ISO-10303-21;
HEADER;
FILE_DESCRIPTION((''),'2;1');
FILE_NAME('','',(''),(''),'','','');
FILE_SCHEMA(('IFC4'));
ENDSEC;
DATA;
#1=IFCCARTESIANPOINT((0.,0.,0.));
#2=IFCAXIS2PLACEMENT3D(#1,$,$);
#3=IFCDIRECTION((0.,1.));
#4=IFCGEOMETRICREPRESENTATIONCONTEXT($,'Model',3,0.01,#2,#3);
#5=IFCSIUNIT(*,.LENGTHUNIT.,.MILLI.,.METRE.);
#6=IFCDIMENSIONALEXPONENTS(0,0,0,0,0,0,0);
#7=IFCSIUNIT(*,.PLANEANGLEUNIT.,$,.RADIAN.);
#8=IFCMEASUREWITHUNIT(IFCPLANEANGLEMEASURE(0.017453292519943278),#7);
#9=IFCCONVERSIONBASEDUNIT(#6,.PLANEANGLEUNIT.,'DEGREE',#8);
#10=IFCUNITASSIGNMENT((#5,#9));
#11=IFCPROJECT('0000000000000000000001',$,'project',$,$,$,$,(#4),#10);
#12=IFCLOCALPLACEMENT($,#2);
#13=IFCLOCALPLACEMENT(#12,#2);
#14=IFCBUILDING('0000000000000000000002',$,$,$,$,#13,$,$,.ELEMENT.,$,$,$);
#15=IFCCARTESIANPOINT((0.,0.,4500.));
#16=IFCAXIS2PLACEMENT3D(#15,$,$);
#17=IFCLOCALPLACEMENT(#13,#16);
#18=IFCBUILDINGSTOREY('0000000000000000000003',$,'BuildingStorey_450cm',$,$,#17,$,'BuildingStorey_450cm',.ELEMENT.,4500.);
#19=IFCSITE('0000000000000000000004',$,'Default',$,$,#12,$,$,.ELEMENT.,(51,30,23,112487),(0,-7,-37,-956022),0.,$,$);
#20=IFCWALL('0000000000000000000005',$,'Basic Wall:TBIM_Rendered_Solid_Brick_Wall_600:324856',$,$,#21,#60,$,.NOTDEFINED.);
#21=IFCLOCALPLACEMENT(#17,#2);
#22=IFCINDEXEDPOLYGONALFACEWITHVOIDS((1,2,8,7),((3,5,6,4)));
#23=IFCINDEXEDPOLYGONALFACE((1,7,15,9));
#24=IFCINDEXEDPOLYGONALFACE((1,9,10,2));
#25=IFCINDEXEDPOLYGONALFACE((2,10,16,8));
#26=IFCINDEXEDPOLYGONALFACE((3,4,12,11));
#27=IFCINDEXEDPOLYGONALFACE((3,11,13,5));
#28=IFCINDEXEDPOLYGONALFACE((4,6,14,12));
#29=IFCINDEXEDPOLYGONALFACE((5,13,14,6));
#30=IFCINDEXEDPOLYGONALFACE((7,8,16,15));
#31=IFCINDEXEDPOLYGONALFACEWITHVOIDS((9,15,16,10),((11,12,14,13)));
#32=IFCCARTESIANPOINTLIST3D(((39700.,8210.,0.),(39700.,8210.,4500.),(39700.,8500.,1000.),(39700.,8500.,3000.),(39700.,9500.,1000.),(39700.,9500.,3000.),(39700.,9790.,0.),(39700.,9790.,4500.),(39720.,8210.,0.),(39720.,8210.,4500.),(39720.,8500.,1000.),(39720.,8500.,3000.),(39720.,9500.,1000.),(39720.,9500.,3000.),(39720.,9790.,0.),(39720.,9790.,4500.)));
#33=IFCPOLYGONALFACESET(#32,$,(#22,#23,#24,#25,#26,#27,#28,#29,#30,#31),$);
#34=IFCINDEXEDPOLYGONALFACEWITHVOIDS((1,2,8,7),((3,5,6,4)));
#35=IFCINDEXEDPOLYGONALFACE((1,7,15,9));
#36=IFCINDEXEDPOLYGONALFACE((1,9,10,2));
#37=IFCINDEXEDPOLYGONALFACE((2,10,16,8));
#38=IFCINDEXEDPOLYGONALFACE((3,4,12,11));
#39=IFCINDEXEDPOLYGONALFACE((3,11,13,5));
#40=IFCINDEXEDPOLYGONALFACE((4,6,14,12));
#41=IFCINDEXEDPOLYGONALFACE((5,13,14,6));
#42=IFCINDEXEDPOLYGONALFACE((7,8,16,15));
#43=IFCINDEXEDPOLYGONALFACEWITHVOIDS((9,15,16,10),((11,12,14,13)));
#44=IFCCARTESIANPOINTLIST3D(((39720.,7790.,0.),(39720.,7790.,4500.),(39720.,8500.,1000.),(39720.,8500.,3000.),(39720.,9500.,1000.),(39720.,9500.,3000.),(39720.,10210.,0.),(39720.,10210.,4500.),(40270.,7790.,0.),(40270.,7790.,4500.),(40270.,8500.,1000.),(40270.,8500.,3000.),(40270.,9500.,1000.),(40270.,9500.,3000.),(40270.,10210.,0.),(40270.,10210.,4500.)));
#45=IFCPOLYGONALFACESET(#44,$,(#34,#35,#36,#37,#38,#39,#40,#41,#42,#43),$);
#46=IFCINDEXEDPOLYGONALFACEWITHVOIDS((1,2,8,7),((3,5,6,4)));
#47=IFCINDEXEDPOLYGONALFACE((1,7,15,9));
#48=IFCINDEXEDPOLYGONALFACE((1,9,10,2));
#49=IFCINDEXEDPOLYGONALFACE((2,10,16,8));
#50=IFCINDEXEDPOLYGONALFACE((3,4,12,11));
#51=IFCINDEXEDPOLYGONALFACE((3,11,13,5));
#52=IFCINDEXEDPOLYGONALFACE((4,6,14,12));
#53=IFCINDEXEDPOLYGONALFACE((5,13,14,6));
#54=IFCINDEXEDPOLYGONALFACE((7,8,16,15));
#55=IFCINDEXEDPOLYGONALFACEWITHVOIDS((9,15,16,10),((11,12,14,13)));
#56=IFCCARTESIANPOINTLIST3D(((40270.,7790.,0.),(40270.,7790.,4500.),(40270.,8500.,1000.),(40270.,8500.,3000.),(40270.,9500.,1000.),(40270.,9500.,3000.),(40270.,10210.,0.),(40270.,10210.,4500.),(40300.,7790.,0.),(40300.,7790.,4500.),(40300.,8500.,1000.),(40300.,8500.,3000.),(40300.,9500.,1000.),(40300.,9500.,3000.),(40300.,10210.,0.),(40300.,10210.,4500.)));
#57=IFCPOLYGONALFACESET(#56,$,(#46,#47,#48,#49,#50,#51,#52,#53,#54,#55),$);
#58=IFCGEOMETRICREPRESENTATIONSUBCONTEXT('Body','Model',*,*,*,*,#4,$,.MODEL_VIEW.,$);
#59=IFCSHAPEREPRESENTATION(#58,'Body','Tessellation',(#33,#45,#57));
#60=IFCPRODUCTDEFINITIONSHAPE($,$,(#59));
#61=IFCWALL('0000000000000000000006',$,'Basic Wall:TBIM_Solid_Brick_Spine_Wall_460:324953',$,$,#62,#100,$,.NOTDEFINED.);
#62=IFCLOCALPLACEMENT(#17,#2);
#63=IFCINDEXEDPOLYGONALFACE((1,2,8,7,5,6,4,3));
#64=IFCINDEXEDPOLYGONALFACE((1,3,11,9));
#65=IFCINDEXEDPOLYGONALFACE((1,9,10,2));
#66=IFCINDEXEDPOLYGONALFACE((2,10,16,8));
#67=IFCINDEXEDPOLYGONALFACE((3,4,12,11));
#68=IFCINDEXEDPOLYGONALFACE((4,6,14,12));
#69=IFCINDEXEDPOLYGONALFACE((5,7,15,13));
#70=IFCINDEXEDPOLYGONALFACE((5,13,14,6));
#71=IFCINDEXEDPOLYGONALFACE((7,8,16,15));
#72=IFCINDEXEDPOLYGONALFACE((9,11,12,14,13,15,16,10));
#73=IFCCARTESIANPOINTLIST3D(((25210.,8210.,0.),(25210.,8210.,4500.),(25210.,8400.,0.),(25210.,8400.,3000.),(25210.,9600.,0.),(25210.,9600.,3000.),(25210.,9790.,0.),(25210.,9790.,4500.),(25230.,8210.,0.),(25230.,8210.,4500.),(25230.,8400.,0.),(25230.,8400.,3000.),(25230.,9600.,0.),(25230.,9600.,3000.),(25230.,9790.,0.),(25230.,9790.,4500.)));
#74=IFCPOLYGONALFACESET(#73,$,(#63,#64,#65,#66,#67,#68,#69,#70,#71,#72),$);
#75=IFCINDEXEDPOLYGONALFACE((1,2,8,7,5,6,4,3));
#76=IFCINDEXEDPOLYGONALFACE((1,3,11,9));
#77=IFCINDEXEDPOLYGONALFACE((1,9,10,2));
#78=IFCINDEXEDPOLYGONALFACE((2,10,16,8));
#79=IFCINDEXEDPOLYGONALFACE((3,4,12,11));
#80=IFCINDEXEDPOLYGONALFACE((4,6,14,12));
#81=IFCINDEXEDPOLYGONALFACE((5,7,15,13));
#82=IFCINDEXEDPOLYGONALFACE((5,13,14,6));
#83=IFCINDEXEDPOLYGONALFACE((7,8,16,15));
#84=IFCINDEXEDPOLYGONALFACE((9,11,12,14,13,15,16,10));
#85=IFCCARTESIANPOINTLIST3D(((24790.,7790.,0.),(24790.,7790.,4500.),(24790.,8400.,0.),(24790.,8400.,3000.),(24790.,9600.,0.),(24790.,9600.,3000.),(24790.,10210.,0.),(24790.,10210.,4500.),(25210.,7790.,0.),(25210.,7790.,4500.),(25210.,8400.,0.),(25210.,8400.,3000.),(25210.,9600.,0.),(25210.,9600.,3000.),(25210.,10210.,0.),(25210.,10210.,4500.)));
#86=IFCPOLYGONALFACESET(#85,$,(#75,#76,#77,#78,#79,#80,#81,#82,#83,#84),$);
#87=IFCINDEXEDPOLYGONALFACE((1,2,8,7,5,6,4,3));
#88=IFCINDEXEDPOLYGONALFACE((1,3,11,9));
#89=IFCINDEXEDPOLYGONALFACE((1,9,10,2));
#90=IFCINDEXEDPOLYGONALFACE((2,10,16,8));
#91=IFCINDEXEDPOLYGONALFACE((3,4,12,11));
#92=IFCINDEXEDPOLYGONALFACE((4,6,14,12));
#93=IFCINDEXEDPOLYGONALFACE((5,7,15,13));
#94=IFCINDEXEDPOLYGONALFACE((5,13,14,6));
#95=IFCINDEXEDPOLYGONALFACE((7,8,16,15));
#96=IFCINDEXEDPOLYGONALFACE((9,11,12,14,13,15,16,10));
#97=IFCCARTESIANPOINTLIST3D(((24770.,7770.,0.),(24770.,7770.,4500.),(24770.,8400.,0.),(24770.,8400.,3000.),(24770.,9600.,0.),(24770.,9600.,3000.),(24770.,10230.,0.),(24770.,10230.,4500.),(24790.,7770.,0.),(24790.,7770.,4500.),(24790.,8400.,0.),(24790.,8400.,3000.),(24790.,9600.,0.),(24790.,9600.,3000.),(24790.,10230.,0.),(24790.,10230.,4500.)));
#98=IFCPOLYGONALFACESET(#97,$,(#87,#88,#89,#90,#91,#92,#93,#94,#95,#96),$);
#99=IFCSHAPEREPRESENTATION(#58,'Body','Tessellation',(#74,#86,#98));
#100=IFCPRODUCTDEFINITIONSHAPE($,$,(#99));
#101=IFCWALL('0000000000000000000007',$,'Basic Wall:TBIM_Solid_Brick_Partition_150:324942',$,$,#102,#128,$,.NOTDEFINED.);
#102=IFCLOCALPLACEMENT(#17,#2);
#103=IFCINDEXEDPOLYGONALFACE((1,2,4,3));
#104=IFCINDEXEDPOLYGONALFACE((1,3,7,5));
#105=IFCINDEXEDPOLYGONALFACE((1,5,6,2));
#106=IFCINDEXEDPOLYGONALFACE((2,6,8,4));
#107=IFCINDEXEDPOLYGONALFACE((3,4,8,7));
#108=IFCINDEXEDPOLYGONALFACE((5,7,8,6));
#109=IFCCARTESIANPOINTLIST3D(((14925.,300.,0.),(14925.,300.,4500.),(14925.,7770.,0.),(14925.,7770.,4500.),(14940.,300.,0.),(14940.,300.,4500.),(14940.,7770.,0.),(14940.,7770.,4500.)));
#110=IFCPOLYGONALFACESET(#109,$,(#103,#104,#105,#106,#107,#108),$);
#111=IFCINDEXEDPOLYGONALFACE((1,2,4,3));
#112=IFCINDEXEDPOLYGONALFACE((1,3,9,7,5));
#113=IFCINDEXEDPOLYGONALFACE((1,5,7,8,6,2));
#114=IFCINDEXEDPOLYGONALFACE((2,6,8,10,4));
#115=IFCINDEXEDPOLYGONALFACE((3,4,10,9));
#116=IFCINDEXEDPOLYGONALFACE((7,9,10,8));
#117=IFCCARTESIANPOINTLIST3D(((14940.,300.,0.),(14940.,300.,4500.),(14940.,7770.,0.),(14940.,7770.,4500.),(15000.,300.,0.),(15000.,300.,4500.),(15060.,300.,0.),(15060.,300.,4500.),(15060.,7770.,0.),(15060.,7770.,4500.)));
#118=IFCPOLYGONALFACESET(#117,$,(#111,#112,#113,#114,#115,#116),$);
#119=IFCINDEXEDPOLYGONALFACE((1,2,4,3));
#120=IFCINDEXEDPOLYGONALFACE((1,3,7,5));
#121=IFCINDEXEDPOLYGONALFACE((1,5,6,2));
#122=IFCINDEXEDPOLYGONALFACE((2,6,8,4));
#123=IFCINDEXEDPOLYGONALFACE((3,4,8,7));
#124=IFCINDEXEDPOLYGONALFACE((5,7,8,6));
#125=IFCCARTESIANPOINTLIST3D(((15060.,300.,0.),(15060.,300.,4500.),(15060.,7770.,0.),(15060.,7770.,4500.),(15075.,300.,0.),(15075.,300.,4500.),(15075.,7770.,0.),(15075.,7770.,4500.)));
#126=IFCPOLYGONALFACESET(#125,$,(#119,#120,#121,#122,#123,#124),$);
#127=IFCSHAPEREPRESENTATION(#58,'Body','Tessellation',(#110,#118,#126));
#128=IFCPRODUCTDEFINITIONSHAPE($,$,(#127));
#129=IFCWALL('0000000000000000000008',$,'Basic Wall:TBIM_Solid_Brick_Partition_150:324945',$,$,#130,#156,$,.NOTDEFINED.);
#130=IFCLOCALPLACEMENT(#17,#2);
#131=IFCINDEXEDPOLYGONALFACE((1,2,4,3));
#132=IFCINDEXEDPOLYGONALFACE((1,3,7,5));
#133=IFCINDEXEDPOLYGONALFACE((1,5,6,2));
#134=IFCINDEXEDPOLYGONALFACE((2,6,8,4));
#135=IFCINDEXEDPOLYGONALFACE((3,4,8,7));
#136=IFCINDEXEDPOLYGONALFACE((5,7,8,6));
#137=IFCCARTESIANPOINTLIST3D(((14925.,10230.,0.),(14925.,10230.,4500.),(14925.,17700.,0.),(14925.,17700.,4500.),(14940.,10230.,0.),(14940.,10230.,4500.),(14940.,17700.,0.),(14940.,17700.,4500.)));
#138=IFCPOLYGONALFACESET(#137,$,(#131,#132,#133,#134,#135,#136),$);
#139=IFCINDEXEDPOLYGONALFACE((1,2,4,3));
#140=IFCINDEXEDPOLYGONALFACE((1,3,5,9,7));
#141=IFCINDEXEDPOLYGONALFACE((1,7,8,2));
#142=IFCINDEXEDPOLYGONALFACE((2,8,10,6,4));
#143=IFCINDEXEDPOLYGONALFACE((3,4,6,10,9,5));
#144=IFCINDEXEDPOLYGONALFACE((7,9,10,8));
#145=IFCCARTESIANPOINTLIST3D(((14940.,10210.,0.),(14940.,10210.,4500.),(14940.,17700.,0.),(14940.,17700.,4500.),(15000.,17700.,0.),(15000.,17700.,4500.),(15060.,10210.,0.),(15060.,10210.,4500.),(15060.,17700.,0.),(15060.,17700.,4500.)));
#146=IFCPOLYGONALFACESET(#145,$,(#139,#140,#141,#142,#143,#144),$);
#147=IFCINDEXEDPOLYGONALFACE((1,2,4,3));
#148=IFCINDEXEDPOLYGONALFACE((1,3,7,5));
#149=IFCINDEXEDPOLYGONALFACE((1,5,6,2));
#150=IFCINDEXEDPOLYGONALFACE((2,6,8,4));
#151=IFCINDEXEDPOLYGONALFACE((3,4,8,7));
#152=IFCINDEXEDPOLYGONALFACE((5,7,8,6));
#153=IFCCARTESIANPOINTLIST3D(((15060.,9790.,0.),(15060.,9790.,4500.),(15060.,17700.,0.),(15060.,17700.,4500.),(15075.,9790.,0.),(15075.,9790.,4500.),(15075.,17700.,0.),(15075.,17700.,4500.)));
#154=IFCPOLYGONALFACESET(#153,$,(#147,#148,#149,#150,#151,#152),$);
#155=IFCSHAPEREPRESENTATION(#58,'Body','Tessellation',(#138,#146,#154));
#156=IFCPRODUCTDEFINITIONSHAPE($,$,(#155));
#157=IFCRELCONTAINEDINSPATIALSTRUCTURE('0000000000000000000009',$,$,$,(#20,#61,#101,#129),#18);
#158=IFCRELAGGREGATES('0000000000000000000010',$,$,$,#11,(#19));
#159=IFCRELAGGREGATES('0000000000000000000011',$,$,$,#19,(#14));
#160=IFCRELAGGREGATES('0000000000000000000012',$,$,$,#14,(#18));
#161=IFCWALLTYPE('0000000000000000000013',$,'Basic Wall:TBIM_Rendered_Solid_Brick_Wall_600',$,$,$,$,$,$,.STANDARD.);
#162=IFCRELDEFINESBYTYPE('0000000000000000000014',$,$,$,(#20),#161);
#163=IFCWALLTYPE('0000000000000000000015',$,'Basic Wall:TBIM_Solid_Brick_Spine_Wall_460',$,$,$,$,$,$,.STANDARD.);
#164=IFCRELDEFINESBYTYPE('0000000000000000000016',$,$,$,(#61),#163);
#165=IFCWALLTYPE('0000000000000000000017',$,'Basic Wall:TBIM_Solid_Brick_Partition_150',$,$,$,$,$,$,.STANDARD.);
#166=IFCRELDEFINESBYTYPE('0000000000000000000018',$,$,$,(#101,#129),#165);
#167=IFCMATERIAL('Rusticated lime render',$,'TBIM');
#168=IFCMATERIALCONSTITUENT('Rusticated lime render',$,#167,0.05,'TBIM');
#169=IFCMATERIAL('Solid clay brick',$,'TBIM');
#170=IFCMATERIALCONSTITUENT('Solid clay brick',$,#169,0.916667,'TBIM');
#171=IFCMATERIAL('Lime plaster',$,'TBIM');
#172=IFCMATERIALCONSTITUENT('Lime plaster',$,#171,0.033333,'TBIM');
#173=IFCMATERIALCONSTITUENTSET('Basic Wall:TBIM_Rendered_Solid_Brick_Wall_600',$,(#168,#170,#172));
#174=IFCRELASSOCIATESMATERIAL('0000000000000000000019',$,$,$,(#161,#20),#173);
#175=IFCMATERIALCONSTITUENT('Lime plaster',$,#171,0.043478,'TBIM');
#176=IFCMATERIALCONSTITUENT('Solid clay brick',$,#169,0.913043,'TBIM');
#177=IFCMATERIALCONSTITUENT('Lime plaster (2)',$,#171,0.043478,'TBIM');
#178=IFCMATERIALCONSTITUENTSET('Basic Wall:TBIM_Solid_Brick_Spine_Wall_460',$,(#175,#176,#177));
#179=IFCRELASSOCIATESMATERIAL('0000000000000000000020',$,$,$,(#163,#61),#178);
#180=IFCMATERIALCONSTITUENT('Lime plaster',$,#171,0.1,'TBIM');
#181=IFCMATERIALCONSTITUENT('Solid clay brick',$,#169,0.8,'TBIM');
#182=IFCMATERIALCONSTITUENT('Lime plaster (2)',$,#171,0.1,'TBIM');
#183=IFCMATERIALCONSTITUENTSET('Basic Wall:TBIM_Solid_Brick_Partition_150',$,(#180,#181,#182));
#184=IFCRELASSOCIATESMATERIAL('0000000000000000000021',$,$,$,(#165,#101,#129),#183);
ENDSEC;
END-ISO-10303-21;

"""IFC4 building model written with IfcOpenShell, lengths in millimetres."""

from ifc_helpers import new_model, entity, si_unit, converted_unit, direction, frame, origin, place, context, subcontext, project, spatial, indexed_curve, outline, extrude, material, constituent, constituent_set, type_object, element, save


model = new_model("IFC4")

# Units and contexts
model_context = context("Model", 3, precision=0.01, world=origin(), true_north=direction((0.0, 1.0)))
body_context = subcontext(model_context, "Body", "Model", "MODEL_VIEW")
ifc_project = project(units=[si_unit("LENGTHUNIT", "METRE", prefix="MILLI"), converted_unit("PLANEANGLEUNIT", "DEGREE", entity("IfcPlaneAngleMeasure", 0.017453292519943278), si_unit("PLANEANGLEUNIT", "RADIAN"), dimensions=[0, 0, 0, 0, 0, 0, 0])], contexts=[model_context])

# Site, building, storey
site_placement = place(None, origin())
site = spatial("IfcSite", under=ifc_project, at=site_placement, Name="Default", CompositionType="ELEMENT", RefLatitude=(51, 30, 23, 112487), RefLongitude=(0, -7, -37, -956022), RefElevation=0.0)
building_placement = place(site_placement, origin())
building = spatial("IfcBuilding", under=site, at=building_placement, CompositionType="ELEMENT")
storey_placement = place(building_placement, frame((0.0, 0.0, 4500.0)))
storey = spatial("IfcBuildingStorey", under=building, at=storey_placement, Name="BuildingStorey_450cm", LongName="BuildingStorey_450cm", CompositionType="ELEMENT", Elevation=4500.0)

# Walls, openings
ifc_material_1 = material(Name="Rusticated lime render", Category="TBIM")
ifc_constituent_1 = constituent(ifc_material_1, Name="Rusticated lime render", Category="TBIM", fraction=0.05)
ifc_material_2 = material(Name="Solid clay brick", Category="TBIM")
ifc_constituent_2 = constituent(ifc_material_2, Name="Solid clay brick", Category="TBIM", fraction=0.916667)
ifc_material_3 = material(Name="Lime plaster", Category="TBIM")
ifc_constituent_3 = constituent(ifc_material_3, Name="Lime plaster", Category="TBIM", fraction=0.033333)
ifc_constituent_set_1 = constituent_set(constituents=[ifc_constituent_1, ifc_constituent_2, ifc_constituent_3], Name="Basic Wall:TBIM_Rendered_Solid_Brick_Wall_600")
wall_type_1 = type_object("IfcWallType", Name="Basic Wall:TBIM_Rendered_Solid_Brick_Wall_600", PredefinedType="STANDARD", material=ifc_constituent_set_1)
wall_1_placement = place(storey_placement, frame((40000.0, 10230.0, 0.0), z_axis=(0.0, 0.0, 1.0), x_axis=(0.0, -1.0, 0.0)))
wall_1 = element("IfcWall", 1, at=wall_1_placement, inside=storey, type_object=wall_type_1, material=ifc_constituent_set_1, Name="Basic Wall:TBIM_Rendered_Solid_Brick_Wall_600:324856", PredefinedType="NOTDEFINED", context=body_context, shape_type="SweptSolid", body=[
    extrude(outline(indexed_curve([(-2250.0, -790.0), (2250.0, -790.0), (2250.0, -770.0), (2250.0, 770.0), (2250.0, 790.0), (-2250.0, 790.0), (-2250.0, 770.0), (-2250.0, -770.0), (-2250.0, -790.0)], self_intersect=False), holes=[indexed_curve([(750.0, -500.0), (-1250.0, -500.0), (-1250.0, 500.0), (750.0, 500.0), (750.0, -500.0)], self_intersect=False)]), frame((1230.0, -300.0, 2250.0), z_axis=(0.0, 1.0, 0.0), x_axis=(0.0, 0.0, 1.0)), (0.0, 0.0, 1.0), 20.0),
    extrude(outline(indexed_curve([(-2250.0, -1210.0), (2250.0, -1210.0), (2250.0, 1210.0), (-2250.0, 1210.0), (-2250.0, -1210.0)], self_intersect=False), holes=[indexed_curve([(-1250.0, -500.0), (-1250.0, 500.0), (750.0, 500.0), (750.0, -500.0), (-1250.0, -500.0)], self_intersect=False)]), frame((1230.0, -280.0, 2250.0), z_axis=(0.0, 1.0, 0.0), x_axis=(0.0, 0.0, 1.0)), (0.0, 0.0, 1.0), 550.0),
    extrude(outline(indexed_curve([(-2250.0, -1210.0), (2250.0, -1210.0), (2250.0, 1210.0), (-2250.0, 1210.0), (-2250.0, -1210.0)], self_intersect=False), holes=[indexed_curve([(-1250.0, -500.0), (-1250.0, 500.0), (750.0, 500.0), (750.0, -500.0), (-1250.0, -500.0)], self_intersect=False)]), frame((1230.0, 270.0, 2250.0), z_axis=(0.0, 1.0, 0.0), x_axis=(0.0, 0.0, 1.0)), (0.0, 0.0, 1.0), 30.0),
])
opening_1_placement = place(wall_1_placement, frame((730.0, -300.0, 1000.0)))
element("IfcOpeningElement", 2, at=opening_1_placement, cuts=wall_1, PredefinedType="OPENING", context=body_context, shape_type="SweptSolid", body=[
    extrude(outline(indexed_curve([(2000.0, 0.0), (2000.0, 1000.0), (0.0, 1000.0), (0.0, 0.0), (2000.0, 0.0)], self_intersect=False)), frame((0.0, 0.0, 0.0), z_axis=(0.0, 1.0, 0.0), x_axis=(0.0, 0.0, 1.0)), (0.0, 0.0, 1.0), 600.0),
])
ifc_constituent_4 = constituent(ifc_material_3, Name="Lime plaster", Category="TBIM", fraction=0.043478)
ifc_constituent_5 = constituent(ifc_material_2, Name="Solid clay brick", Category="TBIM", fraction=0.913043)
ifc_constituent_6 = constituent(ifc_material_3, Name="Lime plaster (2)", Category="TBIM", fraction=0.043478)
ifc_constituent_set_2 = constituent_set(constituents=[ifc_constituent_4, ifc_constituent_5, ifc_constituent_6], Name="Basic Wall:TBIM_Solid_Brick_Spine_Wall_460")
wall_type_2 = type_object("IfcWallType", Name="Basic Wall:TBIM_Solid_Brick_Spine_Wall_460", PredefinedType="STANDARD", material=ifc_constituent_set_2)
wall_2_placement = place(storey_placement, frame((25000.0, 10230.0, 0.0), z_axis=(0.0, 0.0, 1.0), x_axis=(0.0, -1.0, 0.0)))
wall_2 = element("IfcWall", 3, at=wall_2_placement, inside=storey, type_object=wall_type_2, material=ifc_constituent_set_2, Name="Basic Wall:TBIM_Solid_Brick_Spine_Wall_460:324953", PredefinedType="NOTDEFINED", context=body_context, shape_type="SweptSolid", body=[
    extrude(outline(indexed_curve([(-1875.0, -790.0), (2625.0, -790.0), (2625.0, 790.0), (-1875.0, 790.0), (-1875.0, 600.0), (1125.0, 600.0), (1125.0, -600.0), (-1875.0, -600.0), (-1875.0, -790.0)], self_intersect=False)), frame((1230.0, 210.0, 1875.0), z_axis=(0.0, 1.0, 0.0), x_axis=(0.0, 0.0, 1.0)), (0.0, 0.0, 1.0), 20.0),
    extrude(outline(indexed_curve([(-1875.0, -1210.0), (2625.0, -1210.0), (2625.0, 1210.0), (-1875.0, 1210.0), (-1875.0, 600.0), (1125.0, 600.0), (1125.0, -600.0), (-1875.0, -600.0), (-1875.0, -1210.0)], self_intersect=False)), frame((1230.0, -210.0, 1875.0), z_axis=(0.0, 1.0, 0.0), x_axis=(0.0, 0.0, 1.0)), (0.0, 0.0, 1.0), 420.0),
    extrude(outline(indexed_curve([(-2625.0, -1230.0), (1875.0, -1230.0), (1875.0, -600.0), (-1125.0, -600.0), (-1125.0, 600.0), (1875.0, 600.0), (1875.0, 1230.0), (-2625.0, 1230.0), (-2625.0, -1230.0)], self_intersect=False)), frame((1230.0, -230.0, 1875.0), z_axis=(0.0, 1.0, 0.0), x_axis=(0.0, 0.0, -1.0)), (0.0, 0.0, 1.0), 20.0),
])
opening_2_placement = place(wall_2_placement, frame((630.0, -230.0, 0.0)))
element("IfcOpeningElement", 4, at=opening_2_placement, cuts=wall_2, PredefinedType="OPENING", context=body_context, shape_type="SweptSolid", body=[
    extrude(outline(indexed_curve([(0.0, 1200.0), (0.0, 0.0), (3000.0, 0.0), (3000.0, 1200.0), (0.0, 1200.0)], self_intersect=False)), frame((0.0, 0.0, 0.0), z_axis=(0.0, 1.0, 0.0), x_axis=(0.0, 0.0, 1.0)), (0.0, 0.0, 1.0), 460.0),
])

# Walls
ifc_constituent_7 = constituent(ifc_material_3, Name="Lime plaster", Category="TBIM", fraction=0.1)
ifc_constituent_8 = constituent(ifc_material_2, Name="Solid clay brick", Category="TBIM", fraction=0.8)
ifc_constituent_9 = constituent(ifc_material_3, Name="Lime plaster (2)", Category="TBIM", fraction=0.1)
ifc_constituent_set_3 = constituent_set(constituents=[ifc_constituent_7, ifc_constituent_8, ifc_constituent_9], Name="Basic Wall:TBIM_Solid_Brick_Partition_150")
wall_type_3 = type_object("IfcWallType", Name="Basic Wall:TBIM_Solid_Brick_Partition_150", PredefinedType="STANDARD", material=ifc_constituent_set_3)
wall_3_placement = place(storey_placement, frame((15000.0, 300.0, 0.0), z_axis=(0.0, 0.0, 1.0), x_axis=(0.0, 1.0, 0.0)))
element("IfcWall", 5, at=wall_3_placement, inside=storey, type_object=wall_type_3, material=ifc_constituent_set_3, Name="Basic Wall:TBIM_Solid_Brick_Partition_150:324942", PredefinedType="NOTDEFINED", context=body_context, shape_type="SweptSolid", body=[
    extrude(outline(indexed_curve([(-7.5, -3735.0), (7.5, -3735.0), (7.5, 3735.0), (-7.5, 3735.0), (-7.5, -3735.0)], self_intersect=False)), frame((3735.0, 67.5, 0.0), z_axis=(0.0, 0.0, 1.0), x_axis=(0.0, -1.0, 0.0)), (0.0, 0.0, 1.0), 4500.0),
    extrude(outline(indexed_curve([(-2988.0, -60.0), (4482.0, -60.0), (4482.0, 60.0), (-2988.0, 60.0), (-2988.0, 0.0), (-2988.0, -60.0)], self_intersect=False)), frame((2988.0, 0.0, 0.0)), (0.0, 0.0, 1.0), 4500.0),
    extrude(outline(indexed_curve([(-7.5, -3735.0), (7.5, -3735.0), (7.5, 3735.0), (-7.5, 3735.0), (-7.5, -3735.0)], self_intersect=False)), frame((3735.0, -67.5, 0.0), z_axis=(0.0, 0.0, 1.0), x_axis=(0.0, 1.0, 0.0)), (0.0, 0.0, 1.0), 4500.0),
])
wall_4_placement = place(storey_placement, frame((15000.0, 10230.0, 0.0), z_axis=(0.0, 0.0, 1.0), x_axis=(0.0, 1.0, 0.0)))
element("IfcWall", 6, at=wall_4_placement, inside=storey, type_object=wall_type_3, material=ifc_constituent_set_3, Name="Basic Wall:TBIM_Solid_Brick_Partition_150:324945", PredefinedType="NOTDEFINED", context=body_context, shape_type="SweptSolid", body=[
    extrude(outline(indexed_curve([(-7.5, -3735.0), (7.5, -3735.0), (7.5, 3735.0), (-7.5, 3735.0), (-7.5, -3735.0)], self_intersect=False)), frame((3735.0, 67.5, 0.0), z_axis=(0.0, 0.0, 1.0), x_axis=(0.0, -1.0, 0.0)), (0.0, 0.0, 1.0), 4500.0),
    extrude(outline(indexed_curve([(-4494.0, -60.0), (2996.0, -60.0), (2996.0, 0.0), (2996.0, 60.0), (-4494.0, 60.0), (-4494.0, -60.0)], self_intersect=False)), frame((4474.0, 0.0, 0.0)), (0.0, 0.0, 1.0), 4500.0),
    extrude(outline(indexed_curve([(-7.5, -3955.0), (7.5, -3955.0), (7.5, 3955.0), (-7.5, 3955.0), (-7.5, -3955.0)], self_intersect=False)), frame((3515.0, -67.5, 0.0), z_axis=(0.0, 0.0, 1.0), x_axis=(0.0, 1.0, 0.0)), (0.0, 0.0, 1.0), 4500.0),
])

save(model, "model.ifc")
